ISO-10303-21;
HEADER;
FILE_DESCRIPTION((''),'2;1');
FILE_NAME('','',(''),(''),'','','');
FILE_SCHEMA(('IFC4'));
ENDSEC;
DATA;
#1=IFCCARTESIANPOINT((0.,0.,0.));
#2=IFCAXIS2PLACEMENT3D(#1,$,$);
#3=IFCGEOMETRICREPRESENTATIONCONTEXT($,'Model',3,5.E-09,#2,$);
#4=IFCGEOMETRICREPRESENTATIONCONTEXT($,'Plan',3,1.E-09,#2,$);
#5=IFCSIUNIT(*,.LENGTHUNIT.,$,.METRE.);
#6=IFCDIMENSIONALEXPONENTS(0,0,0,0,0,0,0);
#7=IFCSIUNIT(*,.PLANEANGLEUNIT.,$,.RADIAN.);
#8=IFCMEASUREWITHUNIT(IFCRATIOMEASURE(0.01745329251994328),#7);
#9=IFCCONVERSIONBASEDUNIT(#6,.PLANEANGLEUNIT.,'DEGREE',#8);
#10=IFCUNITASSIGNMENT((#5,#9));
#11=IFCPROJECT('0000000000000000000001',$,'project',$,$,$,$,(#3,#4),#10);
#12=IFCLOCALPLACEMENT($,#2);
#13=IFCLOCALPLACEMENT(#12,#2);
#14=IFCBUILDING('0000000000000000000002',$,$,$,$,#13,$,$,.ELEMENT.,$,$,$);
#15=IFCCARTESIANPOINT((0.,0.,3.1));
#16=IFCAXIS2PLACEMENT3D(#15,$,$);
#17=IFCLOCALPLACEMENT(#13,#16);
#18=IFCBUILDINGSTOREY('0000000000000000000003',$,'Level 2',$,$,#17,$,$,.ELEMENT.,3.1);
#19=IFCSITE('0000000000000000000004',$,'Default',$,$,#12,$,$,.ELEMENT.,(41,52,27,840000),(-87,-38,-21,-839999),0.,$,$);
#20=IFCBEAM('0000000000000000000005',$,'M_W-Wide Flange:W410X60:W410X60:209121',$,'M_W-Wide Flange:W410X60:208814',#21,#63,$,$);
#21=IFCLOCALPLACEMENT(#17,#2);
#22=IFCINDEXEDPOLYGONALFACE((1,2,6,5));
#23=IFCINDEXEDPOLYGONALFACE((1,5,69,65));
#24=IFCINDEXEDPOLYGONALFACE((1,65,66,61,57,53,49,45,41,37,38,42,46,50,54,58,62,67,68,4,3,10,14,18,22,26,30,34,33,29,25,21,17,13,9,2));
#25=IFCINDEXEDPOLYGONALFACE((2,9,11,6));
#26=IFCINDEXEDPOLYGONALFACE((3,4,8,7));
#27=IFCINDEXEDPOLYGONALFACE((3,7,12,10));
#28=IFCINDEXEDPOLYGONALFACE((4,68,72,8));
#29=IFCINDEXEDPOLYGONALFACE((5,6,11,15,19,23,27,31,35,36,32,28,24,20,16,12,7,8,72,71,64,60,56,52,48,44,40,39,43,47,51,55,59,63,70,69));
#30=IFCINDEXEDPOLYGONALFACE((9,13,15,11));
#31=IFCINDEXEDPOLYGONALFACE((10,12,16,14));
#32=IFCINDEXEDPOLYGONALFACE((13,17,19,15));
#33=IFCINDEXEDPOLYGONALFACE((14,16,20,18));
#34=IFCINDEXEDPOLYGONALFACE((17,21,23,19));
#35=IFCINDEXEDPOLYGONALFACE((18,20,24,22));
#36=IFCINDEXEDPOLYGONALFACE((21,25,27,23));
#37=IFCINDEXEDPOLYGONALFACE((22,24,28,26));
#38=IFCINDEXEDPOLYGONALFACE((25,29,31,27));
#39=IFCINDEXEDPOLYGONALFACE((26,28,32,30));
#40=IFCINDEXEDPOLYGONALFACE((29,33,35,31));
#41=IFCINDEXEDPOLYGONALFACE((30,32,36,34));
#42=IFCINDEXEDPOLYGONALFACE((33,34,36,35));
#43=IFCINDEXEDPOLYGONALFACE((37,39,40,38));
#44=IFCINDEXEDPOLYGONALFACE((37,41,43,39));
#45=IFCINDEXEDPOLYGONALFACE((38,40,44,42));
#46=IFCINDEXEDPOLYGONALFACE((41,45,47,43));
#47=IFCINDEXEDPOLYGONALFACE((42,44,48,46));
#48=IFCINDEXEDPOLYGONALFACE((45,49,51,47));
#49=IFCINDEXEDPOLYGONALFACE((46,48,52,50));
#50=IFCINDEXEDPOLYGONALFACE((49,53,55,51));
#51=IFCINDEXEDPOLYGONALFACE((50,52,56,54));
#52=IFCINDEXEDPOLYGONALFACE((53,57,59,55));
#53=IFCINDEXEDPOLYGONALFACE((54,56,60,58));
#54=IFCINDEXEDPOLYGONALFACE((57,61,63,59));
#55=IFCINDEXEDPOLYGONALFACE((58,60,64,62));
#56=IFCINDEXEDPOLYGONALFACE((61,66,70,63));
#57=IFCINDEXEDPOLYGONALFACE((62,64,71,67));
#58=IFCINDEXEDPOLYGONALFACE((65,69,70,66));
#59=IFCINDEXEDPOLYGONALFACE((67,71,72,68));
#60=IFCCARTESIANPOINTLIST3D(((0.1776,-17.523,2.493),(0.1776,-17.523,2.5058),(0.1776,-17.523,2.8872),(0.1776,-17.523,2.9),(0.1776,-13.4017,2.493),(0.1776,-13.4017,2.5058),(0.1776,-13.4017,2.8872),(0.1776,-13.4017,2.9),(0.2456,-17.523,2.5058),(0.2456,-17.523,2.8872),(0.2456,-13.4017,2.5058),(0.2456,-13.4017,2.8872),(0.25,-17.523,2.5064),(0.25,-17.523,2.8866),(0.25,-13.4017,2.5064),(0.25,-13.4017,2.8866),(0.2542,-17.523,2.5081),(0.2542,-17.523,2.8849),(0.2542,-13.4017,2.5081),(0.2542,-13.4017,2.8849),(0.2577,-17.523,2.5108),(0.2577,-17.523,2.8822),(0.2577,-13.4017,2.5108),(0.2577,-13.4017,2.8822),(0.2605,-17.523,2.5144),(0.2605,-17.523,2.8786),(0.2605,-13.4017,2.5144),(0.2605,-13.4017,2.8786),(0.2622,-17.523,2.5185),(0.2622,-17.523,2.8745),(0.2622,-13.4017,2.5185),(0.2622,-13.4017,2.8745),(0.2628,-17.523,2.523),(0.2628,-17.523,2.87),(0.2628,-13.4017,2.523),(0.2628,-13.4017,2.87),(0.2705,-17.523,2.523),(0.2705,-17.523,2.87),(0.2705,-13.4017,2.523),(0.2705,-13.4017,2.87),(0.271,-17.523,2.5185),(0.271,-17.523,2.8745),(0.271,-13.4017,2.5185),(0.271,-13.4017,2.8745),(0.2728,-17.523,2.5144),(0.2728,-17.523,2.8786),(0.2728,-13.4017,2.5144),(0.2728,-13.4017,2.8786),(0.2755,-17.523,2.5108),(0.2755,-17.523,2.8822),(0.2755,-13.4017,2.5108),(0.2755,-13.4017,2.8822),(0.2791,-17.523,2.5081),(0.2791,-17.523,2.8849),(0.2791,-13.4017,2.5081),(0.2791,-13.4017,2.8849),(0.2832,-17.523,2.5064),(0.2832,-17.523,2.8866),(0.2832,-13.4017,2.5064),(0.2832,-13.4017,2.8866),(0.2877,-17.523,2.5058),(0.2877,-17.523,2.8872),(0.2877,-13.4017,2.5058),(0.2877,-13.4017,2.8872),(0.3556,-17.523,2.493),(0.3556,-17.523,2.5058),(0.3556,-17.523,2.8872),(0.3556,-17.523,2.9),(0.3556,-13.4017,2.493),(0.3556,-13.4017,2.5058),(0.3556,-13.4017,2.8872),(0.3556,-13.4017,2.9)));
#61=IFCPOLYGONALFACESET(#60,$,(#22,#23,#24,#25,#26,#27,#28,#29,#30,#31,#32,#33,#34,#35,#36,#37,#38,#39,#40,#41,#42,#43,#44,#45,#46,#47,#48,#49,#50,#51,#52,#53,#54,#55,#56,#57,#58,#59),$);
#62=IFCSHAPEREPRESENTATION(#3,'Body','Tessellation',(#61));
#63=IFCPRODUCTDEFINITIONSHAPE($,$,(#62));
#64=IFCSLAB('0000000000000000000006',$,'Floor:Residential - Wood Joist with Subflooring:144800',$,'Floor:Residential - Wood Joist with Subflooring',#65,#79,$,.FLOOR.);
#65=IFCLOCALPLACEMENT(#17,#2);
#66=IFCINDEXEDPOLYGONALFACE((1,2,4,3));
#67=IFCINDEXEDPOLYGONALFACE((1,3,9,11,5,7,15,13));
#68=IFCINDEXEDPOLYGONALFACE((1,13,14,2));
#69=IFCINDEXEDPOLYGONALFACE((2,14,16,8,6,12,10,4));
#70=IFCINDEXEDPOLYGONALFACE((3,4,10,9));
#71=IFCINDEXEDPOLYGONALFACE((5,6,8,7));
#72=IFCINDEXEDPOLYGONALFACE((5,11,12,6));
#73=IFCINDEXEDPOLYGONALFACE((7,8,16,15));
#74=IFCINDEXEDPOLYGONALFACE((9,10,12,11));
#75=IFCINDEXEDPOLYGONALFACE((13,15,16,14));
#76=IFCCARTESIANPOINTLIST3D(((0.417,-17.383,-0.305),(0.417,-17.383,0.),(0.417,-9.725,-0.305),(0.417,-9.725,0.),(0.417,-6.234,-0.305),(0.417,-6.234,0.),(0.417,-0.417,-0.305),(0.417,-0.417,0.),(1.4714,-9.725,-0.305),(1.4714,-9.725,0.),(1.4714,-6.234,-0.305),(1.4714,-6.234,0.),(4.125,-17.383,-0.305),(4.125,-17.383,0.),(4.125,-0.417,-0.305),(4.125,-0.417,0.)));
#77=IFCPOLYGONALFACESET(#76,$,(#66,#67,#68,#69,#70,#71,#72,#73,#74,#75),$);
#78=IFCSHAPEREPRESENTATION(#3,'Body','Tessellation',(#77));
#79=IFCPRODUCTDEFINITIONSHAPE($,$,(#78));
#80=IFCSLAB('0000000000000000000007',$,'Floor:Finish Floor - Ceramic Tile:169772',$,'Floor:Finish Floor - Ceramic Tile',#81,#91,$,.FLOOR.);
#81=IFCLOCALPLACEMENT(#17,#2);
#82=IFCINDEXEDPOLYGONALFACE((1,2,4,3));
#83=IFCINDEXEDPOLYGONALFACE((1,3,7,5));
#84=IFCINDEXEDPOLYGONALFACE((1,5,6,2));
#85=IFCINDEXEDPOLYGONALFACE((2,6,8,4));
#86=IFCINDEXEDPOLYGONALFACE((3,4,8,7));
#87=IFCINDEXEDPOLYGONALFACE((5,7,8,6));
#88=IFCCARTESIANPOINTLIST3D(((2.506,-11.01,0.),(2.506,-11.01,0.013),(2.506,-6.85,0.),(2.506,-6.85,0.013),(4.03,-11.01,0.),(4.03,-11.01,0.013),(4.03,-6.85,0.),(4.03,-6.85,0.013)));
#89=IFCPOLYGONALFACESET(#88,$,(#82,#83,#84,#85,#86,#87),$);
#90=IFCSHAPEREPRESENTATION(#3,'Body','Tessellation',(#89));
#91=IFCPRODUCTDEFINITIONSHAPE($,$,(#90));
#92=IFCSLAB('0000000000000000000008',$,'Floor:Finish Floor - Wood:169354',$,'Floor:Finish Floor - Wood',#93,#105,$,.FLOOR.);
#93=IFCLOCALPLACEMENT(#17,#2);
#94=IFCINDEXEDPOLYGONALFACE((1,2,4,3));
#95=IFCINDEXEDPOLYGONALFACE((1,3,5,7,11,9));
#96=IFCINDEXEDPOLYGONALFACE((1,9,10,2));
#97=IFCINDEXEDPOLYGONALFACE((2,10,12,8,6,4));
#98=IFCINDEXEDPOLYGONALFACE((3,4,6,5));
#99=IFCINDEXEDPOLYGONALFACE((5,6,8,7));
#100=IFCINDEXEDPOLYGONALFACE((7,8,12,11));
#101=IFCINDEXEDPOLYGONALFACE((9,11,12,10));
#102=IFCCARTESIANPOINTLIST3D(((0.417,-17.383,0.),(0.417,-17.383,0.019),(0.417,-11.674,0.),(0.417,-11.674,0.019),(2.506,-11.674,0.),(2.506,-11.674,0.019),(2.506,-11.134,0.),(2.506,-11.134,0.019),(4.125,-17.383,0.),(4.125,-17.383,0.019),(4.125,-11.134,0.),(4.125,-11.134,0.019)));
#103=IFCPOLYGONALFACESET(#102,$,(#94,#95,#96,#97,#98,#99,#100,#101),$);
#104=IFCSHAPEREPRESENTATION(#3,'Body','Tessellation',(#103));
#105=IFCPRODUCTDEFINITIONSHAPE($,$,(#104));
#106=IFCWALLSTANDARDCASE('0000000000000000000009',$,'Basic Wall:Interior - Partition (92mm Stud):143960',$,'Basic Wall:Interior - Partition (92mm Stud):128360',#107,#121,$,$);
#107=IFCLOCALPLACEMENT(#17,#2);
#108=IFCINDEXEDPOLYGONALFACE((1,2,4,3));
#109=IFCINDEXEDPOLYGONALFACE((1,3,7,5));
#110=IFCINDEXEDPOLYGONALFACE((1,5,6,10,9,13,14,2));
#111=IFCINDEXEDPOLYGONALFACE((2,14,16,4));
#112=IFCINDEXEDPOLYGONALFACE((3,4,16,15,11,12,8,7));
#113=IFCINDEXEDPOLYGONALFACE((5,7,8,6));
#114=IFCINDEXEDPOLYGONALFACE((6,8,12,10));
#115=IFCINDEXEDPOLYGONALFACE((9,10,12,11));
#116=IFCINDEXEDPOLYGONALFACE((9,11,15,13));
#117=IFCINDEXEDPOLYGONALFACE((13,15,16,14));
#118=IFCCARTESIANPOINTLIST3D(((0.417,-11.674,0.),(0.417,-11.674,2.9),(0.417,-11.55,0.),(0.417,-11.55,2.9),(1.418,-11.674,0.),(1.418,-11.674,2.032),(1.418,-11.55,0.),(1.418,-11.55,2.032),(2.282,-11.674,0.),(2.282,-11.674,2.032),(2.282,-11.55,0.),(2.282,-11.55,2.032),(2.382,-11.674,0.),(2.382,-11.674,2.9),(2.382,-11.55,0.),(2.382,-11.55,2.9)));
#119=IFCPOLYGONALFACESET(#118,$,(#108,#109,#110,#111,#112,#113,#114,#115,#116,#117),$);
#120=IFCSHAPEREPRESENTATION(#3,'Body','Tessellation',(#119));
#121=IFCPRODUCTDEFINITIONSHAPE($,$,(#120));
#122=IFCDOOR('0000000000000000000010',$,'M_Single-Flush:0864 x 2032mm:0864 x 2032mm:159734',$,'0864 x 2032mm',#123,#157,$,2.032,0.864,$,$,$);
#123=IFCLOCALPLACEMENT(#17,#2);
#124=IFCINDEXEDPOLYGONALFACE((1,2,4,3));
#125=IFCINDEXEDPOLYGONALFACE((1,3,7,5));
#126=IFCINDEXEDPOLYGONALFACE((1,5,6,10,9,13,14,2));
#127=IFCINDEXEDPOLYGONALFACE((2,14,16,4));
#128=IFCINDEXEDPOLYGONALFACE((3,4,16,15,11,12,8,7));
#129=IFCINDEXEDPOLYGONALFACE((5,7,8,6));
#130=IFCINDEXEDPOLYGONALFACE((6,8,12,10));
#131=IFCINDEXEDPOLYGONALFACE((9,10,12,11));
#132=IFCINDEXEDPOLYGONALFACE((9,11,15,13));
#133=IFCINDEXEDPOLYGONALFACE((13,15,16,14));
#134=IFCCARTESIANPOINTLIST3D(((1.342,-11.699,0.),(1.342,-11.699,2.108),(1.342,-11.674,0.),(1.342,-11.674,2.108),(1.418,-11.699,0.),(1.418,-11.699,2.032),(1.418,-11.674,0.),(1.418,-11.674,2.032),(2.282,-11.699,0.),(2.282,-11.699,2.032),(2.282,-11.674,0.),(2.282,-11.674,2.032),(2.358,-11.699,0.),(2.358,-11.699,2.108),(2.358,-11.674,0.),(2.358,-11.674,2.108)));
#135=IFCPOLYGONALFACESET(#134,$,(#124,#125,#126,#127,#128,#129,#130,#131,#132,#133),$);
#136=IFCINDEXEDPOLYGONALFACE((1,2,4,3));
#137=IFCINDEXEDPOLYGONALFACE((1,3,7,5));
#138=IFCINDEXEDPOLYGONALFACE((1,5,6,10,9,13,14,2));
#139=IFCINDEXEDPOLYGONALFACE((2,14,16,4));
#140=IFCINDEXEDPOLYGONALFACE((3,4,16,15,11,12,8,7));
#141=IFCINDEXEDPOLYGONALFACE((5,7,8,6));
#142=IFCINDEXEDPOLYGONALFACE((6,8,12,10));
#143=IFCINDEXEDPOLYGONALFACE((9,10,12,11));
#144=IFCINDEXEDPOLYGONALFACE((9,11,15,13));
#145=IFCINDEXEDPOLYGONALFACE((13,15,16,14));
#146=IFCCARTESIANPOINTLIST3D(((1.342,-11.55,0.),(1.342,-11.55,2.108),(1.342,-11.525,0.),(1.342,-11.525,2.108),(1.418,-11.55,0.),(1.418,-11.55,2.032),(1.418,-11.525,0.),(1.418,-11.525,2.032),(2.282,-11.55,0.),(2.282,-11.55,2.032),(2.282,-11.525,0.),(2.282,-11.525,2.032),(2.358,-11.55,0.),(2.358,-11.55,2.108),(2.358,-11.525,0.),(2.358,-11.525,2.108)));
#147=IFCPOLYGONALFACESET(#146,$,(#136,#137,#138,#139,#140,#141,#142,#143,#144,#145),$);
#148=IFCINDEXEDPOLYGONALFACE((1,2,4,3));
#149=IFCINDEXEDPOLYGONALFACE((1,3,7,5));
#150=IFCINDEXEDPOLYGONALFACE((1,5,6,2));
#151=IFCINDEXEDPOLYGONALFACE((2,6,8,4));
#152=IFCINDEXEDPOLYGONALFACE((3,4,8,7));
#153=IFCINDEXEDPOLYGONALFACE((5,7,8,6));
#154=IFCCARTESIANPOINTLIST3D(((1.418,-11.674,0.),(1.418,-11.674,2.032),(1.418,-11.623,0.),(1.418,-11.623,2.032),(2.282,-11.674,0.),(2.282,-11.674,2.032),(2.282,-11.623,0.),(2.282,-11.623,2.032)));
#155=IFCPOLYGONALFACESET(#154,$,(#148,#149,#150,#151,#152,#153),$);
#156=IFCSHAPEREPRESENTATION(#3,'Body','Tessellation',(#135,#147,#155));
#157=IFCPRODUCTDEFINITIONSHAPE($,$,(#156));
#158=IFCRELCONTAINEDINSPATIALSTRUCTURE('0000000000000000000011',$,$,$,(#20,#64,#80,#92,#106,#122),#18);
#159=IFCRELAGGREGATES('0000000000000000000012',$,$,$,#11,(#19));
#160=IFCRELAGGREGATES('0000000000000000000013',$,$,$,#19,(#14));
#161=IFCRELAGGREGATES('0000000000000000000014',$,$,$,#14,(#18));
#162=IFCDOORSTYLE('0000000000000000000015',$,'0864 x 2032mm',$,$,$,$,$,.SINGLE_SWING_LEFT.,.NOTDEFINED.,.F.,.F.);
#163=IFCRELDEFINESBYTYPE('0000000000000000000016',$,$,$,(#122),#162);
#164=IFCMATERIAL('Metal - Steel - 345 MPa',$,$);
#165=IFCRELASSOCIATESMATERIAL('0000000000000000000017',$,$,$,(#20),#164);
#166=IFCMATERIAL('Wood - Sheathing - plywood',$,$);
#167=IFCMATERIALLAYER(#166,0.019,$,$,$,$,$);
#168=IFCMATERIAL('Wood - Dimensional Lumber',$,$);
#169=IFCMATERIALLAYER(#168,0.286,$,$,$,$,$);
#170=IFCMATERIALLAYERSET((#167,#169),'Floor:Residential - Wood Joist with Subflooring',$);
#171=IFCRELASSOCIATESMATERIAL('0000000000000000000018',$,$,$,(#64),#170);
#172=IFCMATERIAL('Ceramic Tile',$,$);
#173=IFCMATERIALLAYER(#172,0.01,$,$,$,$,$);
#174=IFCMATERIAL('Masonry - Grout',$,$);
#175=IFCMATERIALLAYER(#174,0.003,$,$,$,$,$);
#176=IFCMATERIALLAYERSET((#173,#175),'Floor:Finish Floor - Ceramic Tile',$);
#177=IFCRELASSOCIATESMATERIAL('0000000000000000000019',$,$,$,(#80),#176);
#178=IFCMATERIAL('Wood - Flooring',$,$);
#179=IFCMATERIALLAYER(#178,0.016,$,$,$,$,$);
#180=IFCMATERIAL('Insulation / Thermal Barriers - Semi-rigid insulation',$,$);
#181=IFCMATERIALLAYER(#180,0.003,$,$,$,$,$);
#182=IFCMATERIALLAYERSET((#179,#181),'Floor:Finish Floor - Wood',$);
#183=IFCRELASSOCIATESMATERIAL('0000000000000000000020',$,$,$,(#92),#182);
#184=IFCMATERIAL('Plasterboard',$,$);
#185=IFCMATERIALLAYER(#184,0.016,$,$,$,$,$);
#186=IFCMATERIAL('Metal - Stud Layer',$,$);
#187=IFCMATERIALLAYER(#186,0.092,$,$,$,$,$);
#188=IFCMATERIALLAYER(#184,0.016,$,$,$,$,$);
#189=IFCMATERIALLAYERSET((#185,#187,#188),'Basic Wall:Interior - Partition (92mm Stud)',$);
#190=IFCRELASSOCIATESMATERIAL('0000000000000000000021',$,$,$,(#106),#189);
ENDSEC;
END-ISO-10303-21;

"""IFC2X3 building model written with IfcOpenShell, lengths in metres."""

from ifc_helpers import new_model, entity, si_unit, converted_unit, frame, frame_2d, origin, origin_2d_with_axis, place, context, project, spatial, polyline, circle_curve, parameter, trimmed, segment, composite_curve, rectangle, outline, extrude, source, transform, mapped, material, layer, layer_set, layer_usage, type_object, type_shapes, element, fill, save


model = new_model("IFC2X3")

# Units and contexts
model_context = context("Model", 3, precision=5e-09, world=origin())
plan_context = context("Plan", 3, precision=1e-09, world=origin())
ifc_project = project(units=[si_unit("LENGTHUNIT", "METRE"), converted_unit("PLANEANGLEUNIT", "DEGREE", entity("IfcRatioMeasure", 0.01745329251994328), si_unit("PLANEANGLEUNIT", "RADIAN"), dimensions=[0, 0, 0, 0, 0, 0, 0])], contexts=[model_context, plan_context])

# Site, building, storey
site_placement = place(None, origin())
site = spatial("IfcSite", under=ifc_project, at=site_placement, Name="Default", CompositionType="ELEMENT", RefLatitude=(41, 52, 27, 840000), RefLongitude=(-87, -38, -21, -839999), RefElevation=0.0)
building_placement = place(site_placement, origin())
building = spatial("IfcBuilding", under=site, at=building_placement, CompositionType="ELEMENT")
storey_placement = place(building_placement, frame((0.0, 0.0, 3.1)))
storey = spatial("IfcBuildingStorey", under=building, at=storey_placement, Name="Level 2", CompositionType="ELEMENT", Elevation=3.1)

# Beam
ifc_material_1 = material(Name="Metal - Steel - 345 MPa")
beam_placement = place(storey_placement, frame((0.2666, -13.4017, 2.9), z_axis=(0.0, 0.0, 1.0), x_axis=(-1.0, 0.0, 0.0)))
element("IfcBeam", 1, at=beam_placement, inside=storey, material=ifc_material_1, Name="M_W-Wide Flange:W410X60:W410X60:209121", ObjectType="M_W-Wide Flange:W410X60:208814", context=model_context, shape_type="SweptSolid", body=[
    extrude(outline(composite_curve([segment(polyline([(0.1907, -0.089), (0.2035, -0.089)]), True, "CONTINUOUS"), segment(polyline([(0.2035, -0.089), (0.2035, 0.089)]), True, "CONTINUOUS"), segment(polyline([(0.2035, 0.089), (0.1907, 0.089)]), True, "CONTINUOUS"), segment(polyline([(0.1907, 0.089), (0.1907, 0.021)]), True, "CONTINUOUS"), segment(trimmed(circle_curve(frame_2d((0.1735, 0.021), x_axis=(1.0, 0.0)), 0.0172), [parameter(270.0)], [parameter(360.0)], True, "PARAMETER"), False, "CONTINUOUS"), segment(polyline([(0.1735, 0.0038), (-0.1735, 0.0038)]), True, "CONTINUOUS"), segment(trimmed(circle_curve(frame_2d((-0.1735, 0.021), x_axis=(0.0, -1.0)), 0.0172), [parameter(270.0)], [parameter(360.0)], True, "PARAMETER"), False, "CONTINUOUS"), segment(polyline([(-0.1907, 0.021), (-0.1907, 0.089)]), True, "CONTINUOUS"), segment(polyline([(-0.1907, 0.089), (-0.2035, 0.089)]), True, "CONTINUOUS"), segment(polyline([(-0.2035, 0.089), (-0.2035, -0.089)]), True, "CONTINUOUS"), segment(polyline([(-0.2035, -0.089), (-0.1907, -0.089)]), True, "CONTINUOUS"), segment(polyline([(-0.1907, -0.089), (-0.1907, -0.0211)]), True, "CONTINUOUS"), segment(trimmed(circle_curve(frame_2d((-0.1735, -0.0211), x_axis=(-1.0, 0.0)), 0.0172), [parameter(270.0)], [parameter(0.0)], True, "PARAMETER"), False, "CONTINUOUS"), segment(polyline([(-0.1735, -0.0039), (0.1735, -0.0039)]), True, "CONTINUOUS"), segment(trimmed(circle_curve(frame_2d((0.1735, -0.0211), x_axis=(0.0, 1.0)), 0.0172), [parameter(270.0)], [parameter(0.0)], True, "PARAMETER"), False, "CONTINUOUS"), segment(polyline([(0.1907, -0.0211), (0.1907, -0.089)]), True, "CONTINUOUS")], self_intersect=False)), frame((0.0, 4.1213, -0.2035), z_axis=(0.0, -1.0, 0.0), x_axis=(0.0, 0.0, -1.0)), (0.0, 0.0, 1.0), 4.1213),
])

# Slabs
ifc_material_2 = material(Name="Wood - Sheathing - plywood")
ifc_layer_1 = layer(ifc_material_2, 0.019)
ifc_material_3 = material(Name="Wood - Dimensional Lumber")
ifc_layer_2 = layer(ifc_material_3, 0.286)
ifc_layer_set_1 = layer_set([ifc_layer_1, ifc_layer_2], Name="Floor:Residential - Wood Joist with Subflooring")
ifc_layer_usage_1 = layer_usage(ifc_layer_set_1, "AXIS3", "POSITIVE", 0.0)
slab_1_placement = place(storey_placement, frame((0.417, -17.383, -0.305)))
element("IfcSlab", 2, at=slab_1_placement, inside=storey, material=ifc_layer_usage_1, Name="Floor:Residential - Wood Joist with Subflooring:144800", ObjectType="Floor:Residential - Wood Joist with Subflooring", PredefinedType="FLOOR", context=model_context, shape_type="SweptSolid", body=[
    extrude(outline(polyline([(-1.854, 8.483), (-1.854, -8.483), (1.854, -8.483), (1.854, -0.825), (0.7996, -0.825), (0.7996, 2.666), (1.854, 2.666), (1.854, 8.483), (-1.854, 8.483)])), frame((1.854, 8.483, 0.305), z_axis=(0.0, 0.0, -1.0), x_axis=(-1.0, 0.0, 0.0)), (0.0, 0.0, 1.0), 0.305),
])
ifc_material_4 = material(Name="Ceramic Tile")
ifc_layer_3 = layer(ifc_material_4, 0.01)
ifc_material_5 = material(Name="Masonry - Grout")
ifc_layer_4 = layer(ifc_material_5, 0.003)
ifc_layer_set_2 = layer_set([ifc_layer_3, ifc_layer_4], Name="Floor:Finish Floor - Ceramic Tile")
ifc_layer_usage_2 = layer_usage(ifc_layer_set_2, "AXIS3", "POSITIVE", 0.0)
slab_2_placement = place(storey_placement, frame((2.506, -11.01, 0.0)))
element("IfcSlab", 3, at=slab_2_placement, inside=storey, material=ifc_layer_usage_2, Name="Floor:Finish Floor - Ceramic Tile:169772", ObjectType="Floor:Finish Floor - Ceramic Tile", PredefinedType="FLOOR", context=model_context, shape_type="SweptSolid", body=[
    extrude(rectangle(XDim=4.16, YDim=1.524, at=frame_2d((0.0, 0.0), x_axis=(0.0, -1.0))), frame((0.762, 2.08, 0.013), z_axis=(0.0, 0.0, -1.0), x_axis=(-1.0, 0.0, 0.0)), (0.0, 0.0, 1.0), 0.013),
])
ifc_material_6 = material(Name="Wood - Flooring")
ifc_layer_5 = layer(ifc_material_6, 0.016)
ifc_material_7 = material(Name="Insulation / Thermal Barriers - Semi-rigid insulation")
ifc_layer_6 = layer(ifc_material_7, 0.003)
ifc_layer_set_3 = layer_set([ifc_layer_5, ifc_layer_6], Name="Floor:Finish Floor - Wood")
ifc_layer_usage_3 = layer_usage(ifc_layer_set_3, "AXIS3", "POSITIVE", 0.0)
slab_3_placement = place(storey_placement, frame((0.417, -17.383, 0.0)))
element("IfcSlab", 4, at=slab_3_placement, inside=storey, material=ifc_layer_usage_3, Name="Floor:Finish Floor - Wood:169354", ObjectType="Floor:Finish Floor - Wood", PredefinedType="FLOOR", context=model_context, shape_type="SweptSolid", body=[
    extrude(outline(polyline([(-1.854, -3.1245), (1.854, -3.1245), (1.854, 2.5845), (-0.235, 2.5845), (-0.235, 3.1245), (-1.854, 3.1245), (-1.854, -3.1245)])), frame((1.854, 3.1245, 0.019), z_axis=(0.0, 0.0, -1.0), x_axis=(-1.0, 0.0, 0.0)), (0.0, 0.0, 1.0), 0.019),
])

# Shared definitions
ifc_material_8 = material(Name="Metal - Stud Layer")
ifc_material_9 = material(Name="Plasterboard")

# Wall, opening, door
ifc_layer_7 = layer(ifc_material_9, 0.016)
ifc_layer_8 = layer(ifc_material_8, 0.092)
ifc_layer_9 = layer(ifc_material_9, 0.016)
ifc_layer_set_4 = layer_set([ifc_layer_7, ifc_layer_8, ifc_layer_9], Name="Basic Wall:Interior - Partition (92mm Stud)")
ifc_layer_usage_4 = layer_usage(ifc_layer_set_4, "AXIS2", "NEGATIVE", 0.062)
wall_1_placement = place(storey_placement, frame((2.382, -11.612, 0.0), z_axis=(0.0, 0.0, 1.0), x_axis=(-1.0, 0.0, 0.0)))
wall_1 = element("IfcWallStandardCase", 5, at=wall_1_placement, inside=storey, material=ifc_layer_usage_4, Name="Basic Wall:Interior - Partition (92mm Stud):143960", ObjectType="Basic Wall:Interior - Partition (92mm Stud):128360", context=model_context, shape_type="SweptSolid", body=[
    extrude(rectangle(XDim=1.965, YDim=0.124, at=frame_2d((0.9825, 0.0), x_axis=(-1.0, 0.0))), origin(), (0.0, 0.0, 1.0), 2.9),
])
opening_1_placement = place(wall_1_placement, frame((0.1, -0.062, 0.0)))
opening_1 = element("IfcOpeningElement", 6, at=opening_1_placement, cuts=wall_1, ObjectType="Opening", context=model_context, shape_type="SweptSolid", body=[
    extrude(rectangle(XDim=0.864, YDim=2.032, at=frame_2d((1.016, 0.432), x_axis=(0.0, -1.0))), frame((0.0, 0.0, 0.0), z_axis=(0.0, 1.0, 0.0), x_axis=(0.0, 0.0, 1.0)), (0.0, 0.0, 1.0), 0.124),
])
door_style = type_object("IfcDoorStyle", Name="0864 x 2032mm", ConstructionType="NOTDEFINED", OperationType="SINGLE_SWING_LEFT", ParameterTakesPrecedence=False, Sizeable=False)
shared_shape_1 = source(origin(), model_context, "Body", "SweptSolid", [
    extrude(outline(polyline([(-0.508, -1.073), (0.508, -1.073), (0.508, 1.035), (0.432, 1.035), (0.432, -0.997), (-0.432, -0.997), (-0.432, 1.035), (-0.508, 1.035), (-0.508, -1.073)])), frame((0.432, 0.149, 1.035), z_axis=(0.0, -1.0, 0.0), x_axis=(-1.0, 0.0, 0.0)), (0.0, 0.0, 1.0), 0.025),
    extrude(outline(polyline([(-1.073, -0.508), (1.035, -0.508), (1.035, -0.432), (-0.997, -0.432), (-0.997, 0.432), (1.035, 0.432), (1.035, 0.508), (-1.073, 0.508), (-1.073, -0.508)])), frame((0.432, 0.0, 1.035), z_axis=(0.0, -1.0, 0.0), x_axis=(0.0, 0.0, -1.0)), (0.0, 0.0, 1.0), 0.025),
    extrude(rectangle(XDim=0.864, YDim=0.051, at=origin_2d_with_axis()), frame((0.432, 0.0985, 0.0)), (0.0, 0.0, 1.0), 2.032),
])
type_shapes(door_style, [shared_shape_1])
door_placement = place(opening_1_placement, origin())
door = element("IfcDoor", 7, at=door_placement, inside=storey, type_object=door_style, Name="M_Single-Flush:0864 x 2032mm:0864 x 2032mm:159734", ObjectType="0864 x 2032mm", OverallHeight=2.032, OverallWidth=0.864, context=model_context, shape_type="MappedRepresentation", body=[
    mapped(shared_shape_1, transform((0.0, 0.0, 0.0), scale=1.0)),
])
fill(opening_1, door)

save(model, "model.ifc")
